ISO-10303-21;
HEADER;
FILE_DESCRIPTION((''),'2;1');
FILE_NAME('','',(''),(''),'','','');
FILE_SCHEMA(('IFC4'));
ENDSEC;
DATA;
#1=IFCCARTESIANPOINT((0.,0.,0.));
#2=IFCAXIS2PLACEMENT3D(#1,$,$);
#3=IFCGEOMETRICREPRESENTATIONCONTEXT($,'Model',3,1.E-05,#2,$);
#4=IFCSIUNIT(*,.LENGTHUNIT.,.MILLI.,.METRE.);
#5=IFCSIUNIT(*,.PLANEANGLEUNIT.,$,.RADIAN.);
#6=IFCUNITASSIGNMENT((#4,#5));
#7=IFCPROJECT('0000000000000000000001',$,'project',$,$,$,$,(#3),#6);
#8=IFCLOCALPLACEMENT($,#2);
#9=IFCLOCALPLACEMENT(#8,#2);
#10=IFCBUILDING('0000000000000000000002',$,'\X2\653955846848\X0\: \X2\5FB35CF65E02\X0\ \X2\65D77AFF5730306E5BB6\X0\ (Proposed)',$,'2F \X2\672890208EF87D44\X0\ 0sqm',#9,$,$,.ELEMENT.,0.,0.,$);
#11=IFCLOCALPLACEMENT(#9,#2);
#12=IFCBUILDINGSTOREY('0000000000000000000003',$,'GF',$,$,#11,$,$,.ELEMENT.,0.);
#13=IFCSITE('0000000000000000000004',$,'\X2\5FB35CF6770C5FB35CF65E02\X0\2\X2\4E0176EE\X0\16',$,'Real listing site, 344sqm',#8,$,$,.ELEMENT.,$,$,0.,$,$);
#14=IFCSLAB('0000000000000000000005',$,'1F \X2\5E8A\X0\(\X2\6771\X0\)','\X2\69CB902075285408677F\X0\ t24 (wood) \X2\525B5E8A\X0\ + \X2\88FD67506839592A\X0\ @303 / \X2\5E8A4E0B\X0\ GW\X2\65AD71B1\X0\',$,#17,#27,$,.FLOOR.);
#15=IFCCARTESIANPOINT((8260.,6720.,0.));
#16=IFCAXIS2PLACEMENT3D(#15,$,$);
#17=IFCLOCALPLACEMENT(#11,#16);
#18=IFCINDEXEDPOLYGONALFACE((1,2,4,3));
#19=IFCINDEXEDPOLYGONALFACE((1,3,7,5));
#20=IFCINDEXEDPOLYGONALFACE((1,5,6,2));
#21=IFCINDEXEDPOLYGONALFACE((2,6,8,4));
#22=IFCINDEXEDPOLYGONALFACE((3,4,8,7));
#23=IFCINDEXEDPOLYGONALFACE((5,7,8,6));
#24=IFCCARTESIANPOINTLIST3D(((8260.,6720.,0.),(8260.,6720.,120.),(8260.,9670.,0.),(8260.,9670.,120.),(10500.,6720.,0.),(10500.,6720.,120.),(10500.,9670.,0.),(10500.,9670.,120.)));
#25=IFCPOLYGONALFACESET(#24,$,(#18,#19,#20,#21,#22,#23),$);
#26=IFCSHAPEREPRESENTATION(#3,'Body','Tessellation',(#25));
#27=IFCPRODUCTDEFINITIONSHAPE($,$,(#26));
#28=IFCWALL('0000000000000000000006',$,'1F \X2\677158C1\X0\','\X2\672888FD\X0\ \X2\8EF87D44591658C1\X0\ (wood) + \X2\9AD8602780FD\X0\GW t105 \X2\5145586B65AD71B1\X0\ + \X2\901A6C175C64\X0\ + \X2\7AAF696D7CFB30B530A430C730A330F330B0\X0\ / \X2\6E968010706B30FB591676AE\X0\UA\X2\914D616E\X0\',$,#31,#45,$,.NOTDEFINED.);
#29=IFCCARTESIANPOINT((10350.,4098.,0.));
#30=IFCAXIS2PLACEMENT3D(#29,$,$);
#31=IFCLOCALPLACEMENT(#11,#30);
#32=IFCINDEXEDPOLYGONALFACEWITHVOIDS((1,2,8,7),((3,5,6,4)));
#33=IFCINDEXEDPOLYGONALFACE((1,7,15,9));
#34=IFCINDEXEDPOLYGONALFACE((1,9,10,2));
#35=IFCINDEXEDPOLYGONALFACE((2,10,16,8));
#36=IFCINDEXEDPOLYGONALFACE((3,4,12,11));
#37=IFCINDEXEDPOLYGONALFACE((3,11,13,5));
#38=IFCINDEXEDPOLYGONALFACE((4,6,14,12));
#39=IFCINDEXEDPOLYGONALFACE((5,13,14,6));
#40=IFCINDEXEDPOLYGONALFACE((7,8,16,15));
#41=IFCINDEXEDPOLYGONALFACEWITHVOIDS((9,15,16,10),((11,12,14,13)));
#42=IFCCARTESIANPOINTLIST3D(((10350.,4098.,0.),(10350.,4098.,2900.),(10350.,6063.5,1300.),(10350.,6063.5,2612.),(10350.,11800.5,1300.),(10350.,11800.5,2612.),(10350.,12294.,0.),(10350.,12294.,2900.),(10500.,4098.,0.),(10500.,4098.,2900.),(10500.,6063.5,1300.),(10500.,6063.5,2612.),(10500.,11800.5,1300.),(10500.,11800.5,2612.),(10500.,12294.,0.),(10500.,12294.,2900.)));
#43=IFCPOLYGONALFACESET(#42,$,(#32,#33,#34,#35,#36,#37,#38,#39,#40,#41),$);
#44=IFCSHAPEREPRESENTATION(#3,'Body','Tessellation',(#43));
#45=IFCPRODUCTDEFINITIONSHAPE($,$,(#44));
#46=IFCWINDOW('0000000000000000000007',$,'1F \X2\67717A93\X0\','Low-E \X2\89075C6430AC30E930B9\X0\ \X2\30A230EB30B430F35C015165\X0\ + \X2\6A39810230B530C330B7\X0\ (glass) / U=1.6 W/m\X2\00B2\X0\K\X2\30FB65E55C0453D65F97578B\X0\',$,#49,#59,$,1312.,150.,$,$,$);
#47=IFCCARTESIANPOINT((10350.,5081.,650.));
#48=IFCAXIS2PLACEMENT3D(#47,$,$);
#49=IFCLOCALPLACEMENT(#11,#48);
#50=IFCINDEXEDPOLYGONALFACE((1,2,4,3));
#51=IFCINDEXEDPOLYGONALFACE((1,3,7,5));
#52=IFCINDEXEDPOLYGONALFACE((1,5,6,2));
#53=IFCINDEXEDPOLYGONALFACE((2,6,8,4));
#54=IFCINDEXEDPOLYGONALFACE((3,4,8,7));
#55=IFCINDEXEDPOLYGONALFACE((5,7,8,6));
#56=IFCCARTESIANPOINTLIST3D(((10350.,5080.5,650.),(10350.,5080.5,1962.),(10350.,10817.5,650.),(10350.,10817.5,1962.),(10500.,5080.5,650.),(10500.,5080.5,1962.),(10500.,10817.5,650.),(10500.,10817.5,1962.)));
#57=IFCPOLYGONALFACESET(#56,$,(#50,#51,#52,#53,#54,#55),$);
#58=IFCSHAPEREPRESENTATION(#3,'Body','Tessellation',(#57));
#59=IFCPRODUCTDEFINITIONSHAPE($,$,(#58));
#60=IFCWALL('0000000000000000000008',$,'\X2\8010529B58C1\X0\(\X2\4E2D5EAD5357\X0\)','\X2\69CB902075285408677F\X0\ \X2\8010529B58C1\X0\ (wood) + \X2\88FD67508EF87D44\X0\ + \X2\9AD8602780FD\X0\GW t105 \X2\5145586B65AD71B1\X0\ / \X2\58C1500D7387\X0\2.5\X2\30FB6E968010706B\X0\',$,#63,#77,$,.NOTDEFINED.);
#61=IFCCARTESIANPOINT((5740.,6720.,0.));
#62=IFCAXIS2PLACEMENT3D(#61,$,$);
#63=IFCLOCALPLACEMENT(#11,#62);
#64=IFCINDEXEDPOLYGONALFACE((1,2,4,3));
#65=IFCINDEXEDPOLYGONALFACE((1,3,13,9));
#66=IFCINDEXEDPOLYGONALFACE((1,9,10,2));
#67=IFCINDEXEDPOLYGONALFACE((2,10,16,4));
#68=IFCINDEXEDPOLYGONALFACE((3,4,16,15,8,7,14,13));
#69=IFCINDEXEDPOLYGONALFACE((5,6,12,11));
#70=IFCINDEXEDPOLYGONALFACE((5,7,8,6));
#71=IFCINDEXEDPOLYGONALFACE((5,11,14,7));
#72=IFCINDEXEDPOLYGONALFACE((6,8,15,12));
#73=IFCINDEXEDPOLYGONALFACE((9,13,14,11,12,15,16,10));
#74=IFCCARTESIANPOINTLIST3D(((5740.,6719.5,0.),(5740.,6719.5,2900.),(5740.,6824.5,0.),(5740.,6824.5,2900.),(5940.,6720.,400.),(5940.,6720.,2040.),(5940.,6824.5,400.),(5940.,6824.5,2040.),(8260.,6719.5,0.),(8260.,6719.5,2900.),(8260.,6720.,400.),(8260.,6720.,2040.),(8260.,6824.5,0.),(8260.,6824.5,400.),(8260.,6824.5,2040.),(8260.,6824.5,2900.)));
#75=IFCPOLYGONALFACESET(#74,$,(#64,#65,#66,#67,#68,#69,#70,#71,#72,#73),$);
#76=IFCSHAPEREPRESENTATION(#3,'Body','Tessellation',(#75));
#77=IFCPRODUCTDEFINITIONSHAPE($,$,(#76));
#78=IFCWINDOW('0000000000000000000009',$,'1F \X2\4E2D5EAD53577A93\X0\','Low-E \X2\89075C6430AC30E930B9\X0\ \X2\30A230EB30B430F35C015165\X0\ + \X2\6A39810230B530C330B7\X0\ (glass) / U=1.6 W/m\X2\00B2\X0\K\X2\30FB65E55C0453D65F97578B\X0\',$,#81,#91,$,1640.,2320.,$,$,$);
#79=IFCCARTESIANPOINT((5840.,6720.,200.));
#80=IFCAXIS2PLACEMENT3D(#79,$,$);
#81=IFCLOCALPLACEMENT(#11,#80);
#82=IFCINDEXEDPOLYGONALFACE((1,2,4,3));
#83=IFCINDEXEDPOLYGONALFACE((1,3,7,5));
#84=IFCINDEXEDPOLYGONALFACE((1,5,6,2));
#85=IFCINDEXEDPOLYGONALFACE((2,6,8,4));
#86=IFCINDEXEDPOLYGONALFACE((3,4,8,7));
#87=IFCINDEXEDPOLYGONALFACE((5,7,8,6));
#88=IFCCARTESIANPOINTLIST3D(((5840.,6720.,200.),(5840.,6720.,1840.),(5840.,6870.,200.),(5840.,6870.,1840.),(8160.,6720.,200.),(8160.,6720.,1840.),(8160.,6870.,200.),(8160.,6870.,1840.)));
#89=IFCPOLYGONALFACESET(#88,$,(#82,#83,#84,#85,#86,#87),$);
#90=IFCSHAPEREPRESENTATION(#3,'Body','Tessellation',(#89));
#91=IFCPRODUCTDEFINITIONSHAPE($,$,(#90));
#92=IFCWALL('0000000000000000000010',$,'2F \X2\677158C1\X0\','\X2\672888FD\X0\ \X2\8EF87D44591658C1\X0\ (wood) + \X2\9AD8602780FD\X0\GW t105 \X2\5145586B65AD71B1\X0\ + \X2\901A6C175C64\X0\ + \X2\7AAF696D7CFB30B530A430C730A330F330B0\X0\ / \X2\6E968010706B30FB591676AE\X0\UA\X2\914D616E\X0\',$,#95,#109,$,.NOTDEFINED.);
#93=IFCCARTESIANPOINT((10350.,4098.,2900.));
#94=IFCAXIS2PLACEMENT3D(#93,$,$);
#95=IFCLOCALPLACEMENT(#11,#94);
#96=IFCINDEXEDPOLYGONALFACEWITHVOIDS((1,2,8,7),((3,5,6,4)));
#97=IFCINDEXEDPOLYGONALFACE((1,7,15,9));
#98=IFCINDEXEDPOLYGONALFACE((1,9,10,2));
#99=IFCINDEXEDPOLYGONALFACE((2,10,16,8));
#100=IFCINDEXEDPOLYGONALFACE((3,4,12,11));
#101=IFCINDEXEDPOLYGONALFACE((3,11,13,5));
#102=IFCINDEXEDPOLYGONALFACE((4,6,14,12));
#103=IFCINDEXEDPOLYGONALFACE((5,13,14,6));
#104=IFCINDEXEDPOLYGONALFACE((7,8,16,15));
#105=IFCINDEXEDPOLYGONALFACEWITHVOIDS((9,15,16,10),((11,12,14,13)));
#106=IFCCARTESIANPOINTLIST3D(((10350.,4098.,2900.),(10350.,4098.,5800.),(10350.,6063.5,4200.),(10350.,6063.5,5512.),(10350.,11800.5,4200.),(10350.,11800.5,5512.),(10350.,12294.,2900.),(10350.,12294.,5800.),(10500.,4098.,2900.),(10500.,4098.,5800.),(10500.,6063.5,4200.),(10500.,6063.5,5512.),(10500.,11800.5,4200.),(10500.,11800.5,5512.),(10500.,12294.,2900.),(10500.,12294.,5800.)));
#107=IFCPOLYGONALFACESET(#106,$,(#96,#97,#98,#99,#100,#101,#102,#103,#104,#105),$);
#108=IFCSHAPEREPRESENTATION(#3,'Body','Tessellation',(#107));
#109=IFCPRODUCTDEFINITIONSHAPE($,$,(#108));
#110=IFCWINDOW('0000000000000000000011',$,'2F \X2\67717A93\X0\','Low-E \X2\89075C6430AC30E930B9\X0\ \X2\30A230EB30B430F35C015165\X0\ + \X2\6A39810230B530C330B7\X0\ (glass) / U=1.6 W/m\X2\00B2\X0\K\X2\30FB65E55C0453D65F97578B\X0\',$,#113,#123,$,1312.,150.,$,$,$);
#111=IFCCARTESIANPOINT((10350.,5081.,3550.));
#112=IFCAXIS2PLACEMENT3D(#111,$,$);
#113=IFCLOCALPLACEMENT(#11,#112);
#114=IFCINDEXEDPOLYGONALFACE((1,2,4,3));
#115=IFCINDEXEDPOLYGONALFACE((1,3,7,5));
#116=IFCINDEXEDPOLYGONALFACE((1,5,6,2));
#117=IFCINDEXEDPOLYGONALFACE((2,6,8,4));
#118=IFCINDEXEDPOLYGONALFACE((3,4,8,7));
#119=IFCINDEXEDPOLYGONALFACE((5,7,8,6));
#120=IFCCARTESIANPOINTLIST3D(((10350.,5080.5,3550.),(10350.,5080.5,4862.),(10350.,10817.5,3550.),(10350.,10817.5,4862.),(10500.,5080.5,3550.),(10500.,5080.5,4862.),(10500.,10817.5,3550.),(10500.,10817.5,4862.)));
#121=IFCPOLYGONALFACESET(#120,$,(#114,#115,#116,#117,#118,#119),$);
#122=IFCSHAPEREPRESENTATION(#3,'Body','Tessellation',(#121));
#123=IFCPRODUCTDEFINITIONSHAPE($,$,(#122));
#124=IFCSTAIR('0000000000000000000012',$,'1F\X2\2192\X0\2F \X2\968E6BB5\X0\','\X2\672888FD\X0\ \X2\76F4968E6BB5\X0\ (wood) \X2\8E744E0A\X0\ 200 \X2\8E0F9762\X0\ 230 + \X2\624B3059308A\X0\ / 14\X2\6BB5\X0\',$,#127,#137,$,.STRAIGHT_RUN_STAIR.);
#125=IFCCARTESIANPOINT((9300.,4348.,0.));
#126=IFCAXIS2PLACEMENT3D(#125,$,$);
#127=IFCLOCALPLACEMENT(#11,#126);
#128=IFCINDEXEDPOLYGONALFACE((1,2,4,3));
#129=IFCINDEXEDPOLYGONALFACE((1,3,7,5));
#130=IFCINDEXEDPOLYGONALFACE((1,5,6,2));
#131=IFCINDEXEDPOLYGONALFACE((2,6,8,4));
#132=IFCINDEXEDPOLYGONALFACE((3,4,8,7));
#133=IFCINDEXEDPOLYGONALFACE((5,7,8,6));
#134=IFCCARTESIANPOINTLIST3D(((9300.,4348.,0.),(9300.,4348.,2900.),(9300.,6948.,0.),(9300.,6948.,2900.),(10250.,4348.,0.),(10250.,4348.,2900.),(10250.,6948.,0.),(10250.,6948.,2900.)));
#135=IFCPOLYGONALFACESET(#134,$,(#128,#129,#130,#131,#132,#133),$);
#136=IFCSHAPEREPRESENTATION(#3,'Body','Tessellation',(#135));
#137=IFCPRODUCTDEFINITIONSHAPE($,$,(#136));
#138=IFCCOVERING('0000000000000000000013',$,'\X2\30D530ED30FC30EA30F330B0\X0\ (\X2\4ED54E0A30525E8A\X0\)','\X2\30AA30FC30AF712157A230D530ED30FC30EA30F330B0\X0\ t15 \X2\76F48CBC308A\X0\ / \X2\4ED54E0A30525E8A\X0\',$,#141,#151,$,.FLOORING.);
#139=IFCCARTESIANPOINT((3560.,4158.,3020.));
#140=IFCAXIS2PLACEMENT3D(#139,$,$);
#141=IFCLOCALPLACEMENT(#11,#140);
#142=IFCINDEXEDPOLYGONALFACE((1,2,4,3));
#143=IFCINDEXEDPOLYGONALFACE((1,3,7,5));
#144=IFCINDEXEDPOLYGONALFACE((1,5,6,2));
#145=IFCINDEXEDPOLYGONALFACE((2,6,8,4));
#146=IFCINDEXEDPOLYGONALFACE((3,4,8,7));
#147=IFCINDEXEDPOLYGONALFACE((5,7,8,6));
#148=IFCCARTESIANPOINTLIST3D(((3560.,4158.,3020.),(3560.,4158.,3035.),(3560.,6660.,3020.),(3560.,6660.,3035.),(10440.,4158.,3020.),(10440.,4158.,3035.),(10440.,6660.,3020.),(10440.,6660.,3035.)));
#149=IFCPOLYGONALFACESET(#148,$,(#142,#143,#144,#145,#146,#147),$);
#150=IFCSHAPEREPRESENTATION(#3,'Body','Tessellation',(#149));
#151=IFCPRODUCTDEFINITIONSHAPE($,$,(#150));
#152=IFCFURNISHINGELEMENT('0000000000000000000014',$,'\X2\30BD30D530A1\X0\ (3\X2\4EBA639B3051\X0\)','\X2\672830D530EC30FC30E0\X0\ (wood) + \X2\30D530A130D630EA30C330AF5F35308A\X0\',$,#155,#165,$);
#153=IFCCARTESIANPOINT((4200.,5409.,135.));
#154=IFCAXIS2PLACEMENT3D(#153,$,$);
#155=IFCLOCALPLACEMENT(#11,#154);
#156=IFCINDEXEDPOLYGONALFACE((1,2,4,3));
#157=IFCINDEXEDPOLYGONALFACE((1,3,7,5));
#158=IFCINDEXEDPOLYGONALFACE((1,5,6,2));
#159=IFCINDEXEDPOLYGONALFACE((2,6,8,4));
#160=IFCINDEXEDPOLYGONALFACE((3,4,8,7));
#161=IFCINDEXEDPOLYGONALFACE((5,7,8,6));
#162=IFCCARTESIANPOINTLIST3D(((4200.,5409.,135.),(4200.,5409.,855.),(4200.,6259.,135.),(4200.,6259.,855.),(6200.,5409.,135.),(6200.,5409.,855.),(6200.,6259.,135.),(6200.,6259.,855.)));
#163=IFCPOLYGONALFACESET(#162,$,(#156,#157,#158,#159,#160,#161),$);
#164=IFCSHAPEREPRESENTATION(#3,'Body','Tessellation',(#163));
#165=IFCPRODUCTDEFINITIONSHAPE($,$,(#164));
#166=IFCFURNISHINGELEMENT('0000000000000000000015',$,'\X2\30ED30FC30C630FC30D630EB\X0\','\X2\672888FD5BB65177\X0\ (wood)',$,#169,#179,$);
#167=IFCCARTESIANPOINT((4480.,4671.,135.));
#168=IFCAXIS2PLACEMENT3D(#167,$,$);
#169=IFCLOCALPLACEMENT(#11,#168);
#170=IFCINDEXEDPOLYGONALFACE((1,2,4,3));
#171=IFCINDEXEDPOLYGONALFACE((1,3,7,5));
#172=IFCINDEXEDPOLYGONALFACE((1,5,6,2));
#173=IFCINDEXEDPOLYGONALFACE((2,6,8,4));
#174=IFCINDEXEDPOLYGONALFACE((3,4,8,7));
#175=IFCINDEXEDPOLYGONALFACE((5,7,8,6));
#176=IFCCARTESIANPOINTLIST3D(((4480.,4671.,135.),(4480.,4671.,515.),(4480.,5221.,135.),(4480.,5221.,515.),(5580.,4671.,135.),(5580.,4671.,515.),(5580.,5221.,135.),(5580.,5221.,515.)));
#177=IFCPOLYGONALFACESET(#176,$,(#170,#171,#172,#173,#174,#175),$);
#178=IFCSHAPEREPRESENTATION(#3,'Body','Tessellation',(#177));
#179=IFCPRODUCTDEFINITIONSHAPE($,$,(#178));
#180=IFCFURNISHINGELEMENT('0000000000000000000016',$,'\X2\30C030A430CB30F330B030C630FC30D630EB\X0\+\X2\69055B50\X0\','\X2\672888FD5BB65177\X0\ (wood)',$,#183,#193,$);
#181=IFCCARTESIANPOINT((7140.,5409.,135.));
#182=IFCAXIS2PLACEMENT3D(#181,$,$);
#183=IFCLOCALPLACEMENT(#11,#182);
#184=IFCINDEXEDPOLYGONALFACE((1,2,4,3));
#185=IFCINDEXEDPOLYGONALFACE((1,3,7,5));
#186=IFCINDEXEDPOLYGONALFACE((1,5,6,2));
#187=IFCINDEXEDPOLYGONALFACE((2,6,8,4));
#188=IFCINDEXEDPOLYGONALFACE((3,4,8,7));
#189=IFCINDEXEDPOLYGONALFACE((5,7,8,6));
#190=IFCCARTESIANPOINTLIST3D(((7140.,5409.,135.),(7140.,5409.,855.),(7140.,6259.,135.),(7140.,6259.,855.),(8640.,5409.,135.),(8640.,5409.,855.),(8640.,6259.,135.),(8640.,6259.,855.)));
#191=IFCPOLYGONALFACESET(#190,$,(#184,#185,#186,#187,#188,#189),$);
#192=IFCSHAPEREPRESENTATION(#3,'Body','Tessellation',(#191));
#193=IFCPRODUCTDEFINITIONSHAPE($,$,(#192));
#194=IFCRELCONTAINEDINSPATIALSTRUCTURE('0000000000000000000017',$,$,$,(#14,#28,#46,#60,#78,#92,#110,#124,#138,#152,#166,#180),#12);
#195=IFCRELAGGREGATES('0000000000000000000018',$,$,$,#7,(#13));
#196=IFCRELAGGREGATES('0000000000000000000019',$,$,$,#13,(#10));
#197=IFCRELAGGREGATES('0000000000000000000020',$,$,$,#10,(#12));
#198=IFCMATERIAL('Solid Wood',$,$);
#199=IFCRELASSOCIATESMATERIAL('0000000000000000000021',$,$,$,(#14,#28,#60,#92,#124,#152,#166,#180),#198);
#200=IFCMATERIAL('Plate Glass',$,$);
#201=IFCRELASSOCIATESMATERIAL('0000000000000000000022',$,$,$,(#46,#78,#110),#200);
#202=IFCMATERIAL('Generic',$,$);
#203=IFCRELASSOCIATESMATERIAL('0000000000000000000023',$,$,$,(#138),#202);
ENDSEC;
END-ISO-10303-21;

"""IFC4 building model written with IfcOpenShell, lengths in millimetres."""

from ifc_helpers import new_model, si_unit, frame, frame_2d, origin, place, context, project, spatial, rectangle, extrude, material, element, fill, save


model = new_model("IFC4")

# Units and contexts
model_context = context("Model", 3, precision=1e-05, world=origin())
ifc_project = project(units=[si_unit("LENGTHUNIT", "METRE", prefix="MILLI"), si_unit("PLANEANGLEUNIT", "RADIAN")], contexts=[model_context])

# Site, building, storey
site_placement = place(None, origin())
site = spatial("IfcSite", under=ifc_project, at=site_placement, Name="徳島県徳島市2丁目16", ObjectType="Real listing site, 344sqm", CompositionType="ELEMENT", RefElevation=0.0)
building_placement = place(site_placement, origin())
building = spatial("IfcBuilding", under=site, at=building_placement, Name="改善案: 徳島市 旗竿地の家 (Proposed)", ObjectType="2F 木造軸組 0sqm", CompositionType="ELEMENT", ElevationOfRefHeight=0.0, ElevationOfTerrain=0.0)
storey_placement = place(building_placement, origin())
storey = spatial("IfcBuildingStorey", under=building, at=storey_placement, Name="GF", CompositionType="ELEMENT", Elevation=0.0)

# Slab
ifc_material_1 = material(Name="Solid Wood")
slab_placement = place(storey_placement, frame((8260.0, 6720.0, 0.0)))
element("IfcSlab", 1, at=slab_placement, inside=storey, material=ifc_material_1, Name="1F 床(東)", Description="構造用合板 t24 (wood) 剛床 + 製材根太 @303 / 床下 GW断熱", PredefinedType="FLOOR", context=model_context, shape_type="SweptSolid", body=[
    extrude(rectangle(XDim=2240.0, YDim=2950.0, at=frame_2d((1120.0, 1475.0))), frame((8260.0, 6720.0, 0.0)), (0.0, 0.0, 1.0), 120.0),
])

# Walls, openings, windows
wall_1_placement = place(storey_placement, frame((10350.0, 4098.0, 0.0)))
wall_1 = element("IfcWall", 2, at=wall_1_placement, inside=storey, material=ifc_material_1, Name="1F 東壁", Description="木製 軸組外壁 (wood) + 高性能GW t105 充填断熱 + 通気層 + 窯業系サイディング / 準耐火・外皮UA配慮", PredefinedType="NOTDEFINED", context=model_context, shape_type="SweptSolid", body=[
    extrude(rectangle(XDim=150.0, YDim=8196.0, at=frame_2d((75.0, 4098.0))), frame((10350.0, 4098.0, 0.0)), (0.0, 0.0, 1.0), 2900.0),
])
opening_1_placement = place(storey_placement, frame((10350.0, 5081.0, 650.0)))
opening_1 = element("IfcOpeningElement", 3, at=opening_1_placement, cuts=wall_1, PredefinedType="NOTDEFINED", context=model_context, shape_type="SweptSolid", body=[
    extrude(rectangle(XDim=150.0, YDim=5737.0, at=frame_2d((75.0, 2868.0))), frame((10350.0, 5081.0, 650.0)), (0.0, 0.0, 1.0), 1312.0),
])
ifc_material_2 = material(Name="Plate Glass")
window_1_placement = place(storey_placement, frame((10350.0, 5081.0, 650.0)))
window_1 = element("IfcWindow", 4, at=window_1_placement, inside=storey, material=ifc_material_2, Name="1F 東窓", Description="Low-E 複層ガラス アルゴン封入 + 樹脂サッシ (glass) / U=1.6 W/m²K・日射取得型", OverallHeight=1312.0, OverallWidth=150.0, context=model_context, shape_type="SweptSolid", body=[
    extrude(rectangle(XDim=150.0, YDim=5737.0, at=frame_2d((75.0, 2868.0))), frame((10350.0, 5081.0, 650.0)), (0.0, 0.0, 1.0), 1312.0),
])
fill(opening_1, window_1)
wall_2_placement = place(storey_placement, frame((5740.0, 6720.0, 0.0)))
wall_2 = element("IfcWall", 5, at=wall_2_placement, inside=storey, material=ifc_material_1, Name="耐力壁(中庭南)", Description="構造用合板 耐力壁 (wood) + 製材軸組 + 高性能GW t105 充填断熱 / 壁倍率2.5・準耐火", PredefinedType="NOTDEFINED", context=model_context, shape_type="SweptSolid", body=[
    extrude(rectangle(XDim=2520.0, YDim=105.0, at=frame_2d((1260.0, 52.0))), frame((5740.0, 6720.0, 0.0)), (0.0, 0.0, 1.0), 2900.0),
])
opening_2_placement = place(storey_placement, frame((5840.0, 6720.0, 200.0)))
opening_2 = element("IfcOpeningElement", 6, at=opening_2_placement, cuts=wall_2, PredefinedType="NOTDEFINED", context=model_context, shape_type="SweptSolid", body=[
    extrude(rectangle(XDim=2320.0, YDim=150.0, at=frame_2d((1160.0, 75.0))), frame((5840.0, 6720.0, 200.0)), (0.0, 0.0, 1.0), 1640.0),
])
window_2_placement = place(storey_placement, frame((5840.0, 6720.0, 200.0)))
window_2 = element("IfcWindow", 7, at=window_2_placement, inside=storey, material=ifc_material_2, Name="1F 中庭南窓", Description="Low-E 複層ガラス アルゴン封入 + 樹脂サッシ (glass) / U=1.6 W/m²K・日射取得型", OverallHeight=1640.0, OverallWidth=2320.0, context=model_context, shape_type="SweptSolid", body=[
    extrude(rectangle(XDim=2320.0, YDim=150.0, at=frame_2d((1160.0, 75.0))), frame((5840.0, 6720.0, 200.0)), (0.0, 0.0, 1.0), 1640.0),
])
fill(opening_2, window_2)

# Wall, opening, window
wall_3_placement = place(storey_placement, frame((10350.0, 4098.0, 2900.0)))
wall_3 = element("IfcWall", 8, at=wall_3_placement, inside=storey, material=ifc_material_1, Name="2F 東壁", Description="木製 軸組外壁 (wood) + 高性能GW t105 充填断熱 + 通気層 + 窯業系サイディング / 準耐火・外皮UA配慮", PredefinedType="NOTDEFINED", context=model_context, shape_type="SweptSolid", body=[
    extrude(rectangle(XDim=150.0, YDim=8196.0, at=frame_2d((75.0, 4098.0))), frame((10350.0, 4098.0, 2900.0)), (0.0, 0.0, 1.0), 2900.0),
])
opening_3_placement = place(storey_placement, frame((10350.0, 5081.0, 3550.0)))
opening_3 = element("IfcOpeningElement", 9, at=opening_3_placement, cuts=wall_3, PredefinedType="NOTDEFINED", context=model_context, shape_type="SweptSolid", body=[
    extrude(rectangle(XDim=150.0, YDim=5737.0, at=frame_2d((75.0, 2868.0))), frame((10350.0, 5081.0, 3550.0)), (0.0, 0.0, 1.0), 1312.0),
])
window_3_placement = place(storey_placement, frame((10350.0, 5081.0, 3550.0)))
window_3 = element("IfcWindow", 10, at=window_3_placement, inside=storey, material=ifc_material_2, Name="2F 東窓", Description="Low-E 複層ガラス アルゴン封入 + 樹脂サッシ (glass) / U=1.6 W/m²K・日射取得型", OverallHeight=1312.0, OverallWidth=150.0, context=model_context, shape_type="SweptSolid", body=[
    extrude(rectangle(XDim=150.0, YDim=5737.0, at=frame_2d((75.0, 2868.0))), frame((10350.0, 5081.0, 3550.0)), (0.0, 0.0, 1.0), 1312.0),
])
fill(opening_3, window_3)

# Stair
stair_placement = place(storey_placement, frame((9300.0, 4348.0, 0.0)))
element("IfcStair", 11, at=stair_placement, inside=storey, material=ifc_material_1, Name="1F→2F 階段", Description="木製 直階段 (wood) 蹴上 200 踏面 230 + 手すり / 14段", PredefinedType="STRAIGHT_RUN_STAIR", context=model_context, shape_type="SweptSolid", body=[
    extrude(rectangle(XDim=950.0, YDim=2600.0, at=frame_2d((475.0, 1300.0))), frame((9300.0, 4348.0, 0.0)), (0.0, 0.0, 1.0), 2900.0),
])

# Covering
ifc_material_3 = material(Name="Generic")
covering_placement = place(storey_placement, frame((3560.0, 4158.0, 3020.0)))
element("IfcCovering", 12, at=covering_placement, inside=storey, material=ifc_material_3, Name="フローリング (仕上げ床)", Description="オーク無垢フローリング t15 直貼り / 仕上げ床", PredefinedType="FLOORING", context=model_context, shape_type="SweptSolid", body=[
    extrude(rectangle(XDim=6880.0, YDim=2502.0, at=frame_2d((3440.0, 1251.0))), frame((3560.0, 4158.0, 3020.0)), (0.0, 0.0, 1.0), 15.0),
])

# Furnishing elements
furnishing_1_placement = place(storey_placement, frame((4200.0, 5409.0, 135.0)))
element("IfcFurnishingElement", 13, at=furnishing_1_placement, inside=storey, material=ifc_material_1, Name="ソファ (3人掛け)", Description="木フレーム (wood) + ファブリック張り", context=model_context, shape_type="SweptSolid", body=[
    extrude(rectangle(XDim=2000.0, YDim=850.0, at=frame_2d((1000.0, 425.0))), frame((4200.0, 5409.0, 135.0)), (0.0, 0.0, 1.0), 720.0),
])
furnishing_2_placement = place(storey_placement, frame((4480.0, 4671.0, 135.0)))
element("IfcFurnishingElement", 14, at=furnishing_2_placement, inside=storey, material=ifc_material_1, Name="ローテーブル", Description="木製家具 (wood)", context=model_context, shape_type="SweptSolid", body=[
    extrude(rectangle(XDim=1100.0, YDim=550.0, at=frame_2d((550.0, 275.0))), frame((4480.0, 4671.0, 135.0)), (0.0, 0.0, 1.0), 380.0),
])
furnishing_3_placement = place(storey_placement, frame((7140.0, 5409.0, 135.0)))
element("IfcFurnishingElement", 15, at=furnishing_3_placement, inside=storey, material=ifc_material_1, Name="ダイニングテーブル+椅子", Description="木製家具 (wood)", context=model_context, shape_type="SweptSolid", body=[
    extrude(rectangle(XDim=1500.0, YDim=850.0, at=frame_2d((750.0, 425.0))), frame((7140.0, 5409.0, 135.0)), (0.0, 0.0, 1.0), 720.0),
])

save(model, "model.ifc")
